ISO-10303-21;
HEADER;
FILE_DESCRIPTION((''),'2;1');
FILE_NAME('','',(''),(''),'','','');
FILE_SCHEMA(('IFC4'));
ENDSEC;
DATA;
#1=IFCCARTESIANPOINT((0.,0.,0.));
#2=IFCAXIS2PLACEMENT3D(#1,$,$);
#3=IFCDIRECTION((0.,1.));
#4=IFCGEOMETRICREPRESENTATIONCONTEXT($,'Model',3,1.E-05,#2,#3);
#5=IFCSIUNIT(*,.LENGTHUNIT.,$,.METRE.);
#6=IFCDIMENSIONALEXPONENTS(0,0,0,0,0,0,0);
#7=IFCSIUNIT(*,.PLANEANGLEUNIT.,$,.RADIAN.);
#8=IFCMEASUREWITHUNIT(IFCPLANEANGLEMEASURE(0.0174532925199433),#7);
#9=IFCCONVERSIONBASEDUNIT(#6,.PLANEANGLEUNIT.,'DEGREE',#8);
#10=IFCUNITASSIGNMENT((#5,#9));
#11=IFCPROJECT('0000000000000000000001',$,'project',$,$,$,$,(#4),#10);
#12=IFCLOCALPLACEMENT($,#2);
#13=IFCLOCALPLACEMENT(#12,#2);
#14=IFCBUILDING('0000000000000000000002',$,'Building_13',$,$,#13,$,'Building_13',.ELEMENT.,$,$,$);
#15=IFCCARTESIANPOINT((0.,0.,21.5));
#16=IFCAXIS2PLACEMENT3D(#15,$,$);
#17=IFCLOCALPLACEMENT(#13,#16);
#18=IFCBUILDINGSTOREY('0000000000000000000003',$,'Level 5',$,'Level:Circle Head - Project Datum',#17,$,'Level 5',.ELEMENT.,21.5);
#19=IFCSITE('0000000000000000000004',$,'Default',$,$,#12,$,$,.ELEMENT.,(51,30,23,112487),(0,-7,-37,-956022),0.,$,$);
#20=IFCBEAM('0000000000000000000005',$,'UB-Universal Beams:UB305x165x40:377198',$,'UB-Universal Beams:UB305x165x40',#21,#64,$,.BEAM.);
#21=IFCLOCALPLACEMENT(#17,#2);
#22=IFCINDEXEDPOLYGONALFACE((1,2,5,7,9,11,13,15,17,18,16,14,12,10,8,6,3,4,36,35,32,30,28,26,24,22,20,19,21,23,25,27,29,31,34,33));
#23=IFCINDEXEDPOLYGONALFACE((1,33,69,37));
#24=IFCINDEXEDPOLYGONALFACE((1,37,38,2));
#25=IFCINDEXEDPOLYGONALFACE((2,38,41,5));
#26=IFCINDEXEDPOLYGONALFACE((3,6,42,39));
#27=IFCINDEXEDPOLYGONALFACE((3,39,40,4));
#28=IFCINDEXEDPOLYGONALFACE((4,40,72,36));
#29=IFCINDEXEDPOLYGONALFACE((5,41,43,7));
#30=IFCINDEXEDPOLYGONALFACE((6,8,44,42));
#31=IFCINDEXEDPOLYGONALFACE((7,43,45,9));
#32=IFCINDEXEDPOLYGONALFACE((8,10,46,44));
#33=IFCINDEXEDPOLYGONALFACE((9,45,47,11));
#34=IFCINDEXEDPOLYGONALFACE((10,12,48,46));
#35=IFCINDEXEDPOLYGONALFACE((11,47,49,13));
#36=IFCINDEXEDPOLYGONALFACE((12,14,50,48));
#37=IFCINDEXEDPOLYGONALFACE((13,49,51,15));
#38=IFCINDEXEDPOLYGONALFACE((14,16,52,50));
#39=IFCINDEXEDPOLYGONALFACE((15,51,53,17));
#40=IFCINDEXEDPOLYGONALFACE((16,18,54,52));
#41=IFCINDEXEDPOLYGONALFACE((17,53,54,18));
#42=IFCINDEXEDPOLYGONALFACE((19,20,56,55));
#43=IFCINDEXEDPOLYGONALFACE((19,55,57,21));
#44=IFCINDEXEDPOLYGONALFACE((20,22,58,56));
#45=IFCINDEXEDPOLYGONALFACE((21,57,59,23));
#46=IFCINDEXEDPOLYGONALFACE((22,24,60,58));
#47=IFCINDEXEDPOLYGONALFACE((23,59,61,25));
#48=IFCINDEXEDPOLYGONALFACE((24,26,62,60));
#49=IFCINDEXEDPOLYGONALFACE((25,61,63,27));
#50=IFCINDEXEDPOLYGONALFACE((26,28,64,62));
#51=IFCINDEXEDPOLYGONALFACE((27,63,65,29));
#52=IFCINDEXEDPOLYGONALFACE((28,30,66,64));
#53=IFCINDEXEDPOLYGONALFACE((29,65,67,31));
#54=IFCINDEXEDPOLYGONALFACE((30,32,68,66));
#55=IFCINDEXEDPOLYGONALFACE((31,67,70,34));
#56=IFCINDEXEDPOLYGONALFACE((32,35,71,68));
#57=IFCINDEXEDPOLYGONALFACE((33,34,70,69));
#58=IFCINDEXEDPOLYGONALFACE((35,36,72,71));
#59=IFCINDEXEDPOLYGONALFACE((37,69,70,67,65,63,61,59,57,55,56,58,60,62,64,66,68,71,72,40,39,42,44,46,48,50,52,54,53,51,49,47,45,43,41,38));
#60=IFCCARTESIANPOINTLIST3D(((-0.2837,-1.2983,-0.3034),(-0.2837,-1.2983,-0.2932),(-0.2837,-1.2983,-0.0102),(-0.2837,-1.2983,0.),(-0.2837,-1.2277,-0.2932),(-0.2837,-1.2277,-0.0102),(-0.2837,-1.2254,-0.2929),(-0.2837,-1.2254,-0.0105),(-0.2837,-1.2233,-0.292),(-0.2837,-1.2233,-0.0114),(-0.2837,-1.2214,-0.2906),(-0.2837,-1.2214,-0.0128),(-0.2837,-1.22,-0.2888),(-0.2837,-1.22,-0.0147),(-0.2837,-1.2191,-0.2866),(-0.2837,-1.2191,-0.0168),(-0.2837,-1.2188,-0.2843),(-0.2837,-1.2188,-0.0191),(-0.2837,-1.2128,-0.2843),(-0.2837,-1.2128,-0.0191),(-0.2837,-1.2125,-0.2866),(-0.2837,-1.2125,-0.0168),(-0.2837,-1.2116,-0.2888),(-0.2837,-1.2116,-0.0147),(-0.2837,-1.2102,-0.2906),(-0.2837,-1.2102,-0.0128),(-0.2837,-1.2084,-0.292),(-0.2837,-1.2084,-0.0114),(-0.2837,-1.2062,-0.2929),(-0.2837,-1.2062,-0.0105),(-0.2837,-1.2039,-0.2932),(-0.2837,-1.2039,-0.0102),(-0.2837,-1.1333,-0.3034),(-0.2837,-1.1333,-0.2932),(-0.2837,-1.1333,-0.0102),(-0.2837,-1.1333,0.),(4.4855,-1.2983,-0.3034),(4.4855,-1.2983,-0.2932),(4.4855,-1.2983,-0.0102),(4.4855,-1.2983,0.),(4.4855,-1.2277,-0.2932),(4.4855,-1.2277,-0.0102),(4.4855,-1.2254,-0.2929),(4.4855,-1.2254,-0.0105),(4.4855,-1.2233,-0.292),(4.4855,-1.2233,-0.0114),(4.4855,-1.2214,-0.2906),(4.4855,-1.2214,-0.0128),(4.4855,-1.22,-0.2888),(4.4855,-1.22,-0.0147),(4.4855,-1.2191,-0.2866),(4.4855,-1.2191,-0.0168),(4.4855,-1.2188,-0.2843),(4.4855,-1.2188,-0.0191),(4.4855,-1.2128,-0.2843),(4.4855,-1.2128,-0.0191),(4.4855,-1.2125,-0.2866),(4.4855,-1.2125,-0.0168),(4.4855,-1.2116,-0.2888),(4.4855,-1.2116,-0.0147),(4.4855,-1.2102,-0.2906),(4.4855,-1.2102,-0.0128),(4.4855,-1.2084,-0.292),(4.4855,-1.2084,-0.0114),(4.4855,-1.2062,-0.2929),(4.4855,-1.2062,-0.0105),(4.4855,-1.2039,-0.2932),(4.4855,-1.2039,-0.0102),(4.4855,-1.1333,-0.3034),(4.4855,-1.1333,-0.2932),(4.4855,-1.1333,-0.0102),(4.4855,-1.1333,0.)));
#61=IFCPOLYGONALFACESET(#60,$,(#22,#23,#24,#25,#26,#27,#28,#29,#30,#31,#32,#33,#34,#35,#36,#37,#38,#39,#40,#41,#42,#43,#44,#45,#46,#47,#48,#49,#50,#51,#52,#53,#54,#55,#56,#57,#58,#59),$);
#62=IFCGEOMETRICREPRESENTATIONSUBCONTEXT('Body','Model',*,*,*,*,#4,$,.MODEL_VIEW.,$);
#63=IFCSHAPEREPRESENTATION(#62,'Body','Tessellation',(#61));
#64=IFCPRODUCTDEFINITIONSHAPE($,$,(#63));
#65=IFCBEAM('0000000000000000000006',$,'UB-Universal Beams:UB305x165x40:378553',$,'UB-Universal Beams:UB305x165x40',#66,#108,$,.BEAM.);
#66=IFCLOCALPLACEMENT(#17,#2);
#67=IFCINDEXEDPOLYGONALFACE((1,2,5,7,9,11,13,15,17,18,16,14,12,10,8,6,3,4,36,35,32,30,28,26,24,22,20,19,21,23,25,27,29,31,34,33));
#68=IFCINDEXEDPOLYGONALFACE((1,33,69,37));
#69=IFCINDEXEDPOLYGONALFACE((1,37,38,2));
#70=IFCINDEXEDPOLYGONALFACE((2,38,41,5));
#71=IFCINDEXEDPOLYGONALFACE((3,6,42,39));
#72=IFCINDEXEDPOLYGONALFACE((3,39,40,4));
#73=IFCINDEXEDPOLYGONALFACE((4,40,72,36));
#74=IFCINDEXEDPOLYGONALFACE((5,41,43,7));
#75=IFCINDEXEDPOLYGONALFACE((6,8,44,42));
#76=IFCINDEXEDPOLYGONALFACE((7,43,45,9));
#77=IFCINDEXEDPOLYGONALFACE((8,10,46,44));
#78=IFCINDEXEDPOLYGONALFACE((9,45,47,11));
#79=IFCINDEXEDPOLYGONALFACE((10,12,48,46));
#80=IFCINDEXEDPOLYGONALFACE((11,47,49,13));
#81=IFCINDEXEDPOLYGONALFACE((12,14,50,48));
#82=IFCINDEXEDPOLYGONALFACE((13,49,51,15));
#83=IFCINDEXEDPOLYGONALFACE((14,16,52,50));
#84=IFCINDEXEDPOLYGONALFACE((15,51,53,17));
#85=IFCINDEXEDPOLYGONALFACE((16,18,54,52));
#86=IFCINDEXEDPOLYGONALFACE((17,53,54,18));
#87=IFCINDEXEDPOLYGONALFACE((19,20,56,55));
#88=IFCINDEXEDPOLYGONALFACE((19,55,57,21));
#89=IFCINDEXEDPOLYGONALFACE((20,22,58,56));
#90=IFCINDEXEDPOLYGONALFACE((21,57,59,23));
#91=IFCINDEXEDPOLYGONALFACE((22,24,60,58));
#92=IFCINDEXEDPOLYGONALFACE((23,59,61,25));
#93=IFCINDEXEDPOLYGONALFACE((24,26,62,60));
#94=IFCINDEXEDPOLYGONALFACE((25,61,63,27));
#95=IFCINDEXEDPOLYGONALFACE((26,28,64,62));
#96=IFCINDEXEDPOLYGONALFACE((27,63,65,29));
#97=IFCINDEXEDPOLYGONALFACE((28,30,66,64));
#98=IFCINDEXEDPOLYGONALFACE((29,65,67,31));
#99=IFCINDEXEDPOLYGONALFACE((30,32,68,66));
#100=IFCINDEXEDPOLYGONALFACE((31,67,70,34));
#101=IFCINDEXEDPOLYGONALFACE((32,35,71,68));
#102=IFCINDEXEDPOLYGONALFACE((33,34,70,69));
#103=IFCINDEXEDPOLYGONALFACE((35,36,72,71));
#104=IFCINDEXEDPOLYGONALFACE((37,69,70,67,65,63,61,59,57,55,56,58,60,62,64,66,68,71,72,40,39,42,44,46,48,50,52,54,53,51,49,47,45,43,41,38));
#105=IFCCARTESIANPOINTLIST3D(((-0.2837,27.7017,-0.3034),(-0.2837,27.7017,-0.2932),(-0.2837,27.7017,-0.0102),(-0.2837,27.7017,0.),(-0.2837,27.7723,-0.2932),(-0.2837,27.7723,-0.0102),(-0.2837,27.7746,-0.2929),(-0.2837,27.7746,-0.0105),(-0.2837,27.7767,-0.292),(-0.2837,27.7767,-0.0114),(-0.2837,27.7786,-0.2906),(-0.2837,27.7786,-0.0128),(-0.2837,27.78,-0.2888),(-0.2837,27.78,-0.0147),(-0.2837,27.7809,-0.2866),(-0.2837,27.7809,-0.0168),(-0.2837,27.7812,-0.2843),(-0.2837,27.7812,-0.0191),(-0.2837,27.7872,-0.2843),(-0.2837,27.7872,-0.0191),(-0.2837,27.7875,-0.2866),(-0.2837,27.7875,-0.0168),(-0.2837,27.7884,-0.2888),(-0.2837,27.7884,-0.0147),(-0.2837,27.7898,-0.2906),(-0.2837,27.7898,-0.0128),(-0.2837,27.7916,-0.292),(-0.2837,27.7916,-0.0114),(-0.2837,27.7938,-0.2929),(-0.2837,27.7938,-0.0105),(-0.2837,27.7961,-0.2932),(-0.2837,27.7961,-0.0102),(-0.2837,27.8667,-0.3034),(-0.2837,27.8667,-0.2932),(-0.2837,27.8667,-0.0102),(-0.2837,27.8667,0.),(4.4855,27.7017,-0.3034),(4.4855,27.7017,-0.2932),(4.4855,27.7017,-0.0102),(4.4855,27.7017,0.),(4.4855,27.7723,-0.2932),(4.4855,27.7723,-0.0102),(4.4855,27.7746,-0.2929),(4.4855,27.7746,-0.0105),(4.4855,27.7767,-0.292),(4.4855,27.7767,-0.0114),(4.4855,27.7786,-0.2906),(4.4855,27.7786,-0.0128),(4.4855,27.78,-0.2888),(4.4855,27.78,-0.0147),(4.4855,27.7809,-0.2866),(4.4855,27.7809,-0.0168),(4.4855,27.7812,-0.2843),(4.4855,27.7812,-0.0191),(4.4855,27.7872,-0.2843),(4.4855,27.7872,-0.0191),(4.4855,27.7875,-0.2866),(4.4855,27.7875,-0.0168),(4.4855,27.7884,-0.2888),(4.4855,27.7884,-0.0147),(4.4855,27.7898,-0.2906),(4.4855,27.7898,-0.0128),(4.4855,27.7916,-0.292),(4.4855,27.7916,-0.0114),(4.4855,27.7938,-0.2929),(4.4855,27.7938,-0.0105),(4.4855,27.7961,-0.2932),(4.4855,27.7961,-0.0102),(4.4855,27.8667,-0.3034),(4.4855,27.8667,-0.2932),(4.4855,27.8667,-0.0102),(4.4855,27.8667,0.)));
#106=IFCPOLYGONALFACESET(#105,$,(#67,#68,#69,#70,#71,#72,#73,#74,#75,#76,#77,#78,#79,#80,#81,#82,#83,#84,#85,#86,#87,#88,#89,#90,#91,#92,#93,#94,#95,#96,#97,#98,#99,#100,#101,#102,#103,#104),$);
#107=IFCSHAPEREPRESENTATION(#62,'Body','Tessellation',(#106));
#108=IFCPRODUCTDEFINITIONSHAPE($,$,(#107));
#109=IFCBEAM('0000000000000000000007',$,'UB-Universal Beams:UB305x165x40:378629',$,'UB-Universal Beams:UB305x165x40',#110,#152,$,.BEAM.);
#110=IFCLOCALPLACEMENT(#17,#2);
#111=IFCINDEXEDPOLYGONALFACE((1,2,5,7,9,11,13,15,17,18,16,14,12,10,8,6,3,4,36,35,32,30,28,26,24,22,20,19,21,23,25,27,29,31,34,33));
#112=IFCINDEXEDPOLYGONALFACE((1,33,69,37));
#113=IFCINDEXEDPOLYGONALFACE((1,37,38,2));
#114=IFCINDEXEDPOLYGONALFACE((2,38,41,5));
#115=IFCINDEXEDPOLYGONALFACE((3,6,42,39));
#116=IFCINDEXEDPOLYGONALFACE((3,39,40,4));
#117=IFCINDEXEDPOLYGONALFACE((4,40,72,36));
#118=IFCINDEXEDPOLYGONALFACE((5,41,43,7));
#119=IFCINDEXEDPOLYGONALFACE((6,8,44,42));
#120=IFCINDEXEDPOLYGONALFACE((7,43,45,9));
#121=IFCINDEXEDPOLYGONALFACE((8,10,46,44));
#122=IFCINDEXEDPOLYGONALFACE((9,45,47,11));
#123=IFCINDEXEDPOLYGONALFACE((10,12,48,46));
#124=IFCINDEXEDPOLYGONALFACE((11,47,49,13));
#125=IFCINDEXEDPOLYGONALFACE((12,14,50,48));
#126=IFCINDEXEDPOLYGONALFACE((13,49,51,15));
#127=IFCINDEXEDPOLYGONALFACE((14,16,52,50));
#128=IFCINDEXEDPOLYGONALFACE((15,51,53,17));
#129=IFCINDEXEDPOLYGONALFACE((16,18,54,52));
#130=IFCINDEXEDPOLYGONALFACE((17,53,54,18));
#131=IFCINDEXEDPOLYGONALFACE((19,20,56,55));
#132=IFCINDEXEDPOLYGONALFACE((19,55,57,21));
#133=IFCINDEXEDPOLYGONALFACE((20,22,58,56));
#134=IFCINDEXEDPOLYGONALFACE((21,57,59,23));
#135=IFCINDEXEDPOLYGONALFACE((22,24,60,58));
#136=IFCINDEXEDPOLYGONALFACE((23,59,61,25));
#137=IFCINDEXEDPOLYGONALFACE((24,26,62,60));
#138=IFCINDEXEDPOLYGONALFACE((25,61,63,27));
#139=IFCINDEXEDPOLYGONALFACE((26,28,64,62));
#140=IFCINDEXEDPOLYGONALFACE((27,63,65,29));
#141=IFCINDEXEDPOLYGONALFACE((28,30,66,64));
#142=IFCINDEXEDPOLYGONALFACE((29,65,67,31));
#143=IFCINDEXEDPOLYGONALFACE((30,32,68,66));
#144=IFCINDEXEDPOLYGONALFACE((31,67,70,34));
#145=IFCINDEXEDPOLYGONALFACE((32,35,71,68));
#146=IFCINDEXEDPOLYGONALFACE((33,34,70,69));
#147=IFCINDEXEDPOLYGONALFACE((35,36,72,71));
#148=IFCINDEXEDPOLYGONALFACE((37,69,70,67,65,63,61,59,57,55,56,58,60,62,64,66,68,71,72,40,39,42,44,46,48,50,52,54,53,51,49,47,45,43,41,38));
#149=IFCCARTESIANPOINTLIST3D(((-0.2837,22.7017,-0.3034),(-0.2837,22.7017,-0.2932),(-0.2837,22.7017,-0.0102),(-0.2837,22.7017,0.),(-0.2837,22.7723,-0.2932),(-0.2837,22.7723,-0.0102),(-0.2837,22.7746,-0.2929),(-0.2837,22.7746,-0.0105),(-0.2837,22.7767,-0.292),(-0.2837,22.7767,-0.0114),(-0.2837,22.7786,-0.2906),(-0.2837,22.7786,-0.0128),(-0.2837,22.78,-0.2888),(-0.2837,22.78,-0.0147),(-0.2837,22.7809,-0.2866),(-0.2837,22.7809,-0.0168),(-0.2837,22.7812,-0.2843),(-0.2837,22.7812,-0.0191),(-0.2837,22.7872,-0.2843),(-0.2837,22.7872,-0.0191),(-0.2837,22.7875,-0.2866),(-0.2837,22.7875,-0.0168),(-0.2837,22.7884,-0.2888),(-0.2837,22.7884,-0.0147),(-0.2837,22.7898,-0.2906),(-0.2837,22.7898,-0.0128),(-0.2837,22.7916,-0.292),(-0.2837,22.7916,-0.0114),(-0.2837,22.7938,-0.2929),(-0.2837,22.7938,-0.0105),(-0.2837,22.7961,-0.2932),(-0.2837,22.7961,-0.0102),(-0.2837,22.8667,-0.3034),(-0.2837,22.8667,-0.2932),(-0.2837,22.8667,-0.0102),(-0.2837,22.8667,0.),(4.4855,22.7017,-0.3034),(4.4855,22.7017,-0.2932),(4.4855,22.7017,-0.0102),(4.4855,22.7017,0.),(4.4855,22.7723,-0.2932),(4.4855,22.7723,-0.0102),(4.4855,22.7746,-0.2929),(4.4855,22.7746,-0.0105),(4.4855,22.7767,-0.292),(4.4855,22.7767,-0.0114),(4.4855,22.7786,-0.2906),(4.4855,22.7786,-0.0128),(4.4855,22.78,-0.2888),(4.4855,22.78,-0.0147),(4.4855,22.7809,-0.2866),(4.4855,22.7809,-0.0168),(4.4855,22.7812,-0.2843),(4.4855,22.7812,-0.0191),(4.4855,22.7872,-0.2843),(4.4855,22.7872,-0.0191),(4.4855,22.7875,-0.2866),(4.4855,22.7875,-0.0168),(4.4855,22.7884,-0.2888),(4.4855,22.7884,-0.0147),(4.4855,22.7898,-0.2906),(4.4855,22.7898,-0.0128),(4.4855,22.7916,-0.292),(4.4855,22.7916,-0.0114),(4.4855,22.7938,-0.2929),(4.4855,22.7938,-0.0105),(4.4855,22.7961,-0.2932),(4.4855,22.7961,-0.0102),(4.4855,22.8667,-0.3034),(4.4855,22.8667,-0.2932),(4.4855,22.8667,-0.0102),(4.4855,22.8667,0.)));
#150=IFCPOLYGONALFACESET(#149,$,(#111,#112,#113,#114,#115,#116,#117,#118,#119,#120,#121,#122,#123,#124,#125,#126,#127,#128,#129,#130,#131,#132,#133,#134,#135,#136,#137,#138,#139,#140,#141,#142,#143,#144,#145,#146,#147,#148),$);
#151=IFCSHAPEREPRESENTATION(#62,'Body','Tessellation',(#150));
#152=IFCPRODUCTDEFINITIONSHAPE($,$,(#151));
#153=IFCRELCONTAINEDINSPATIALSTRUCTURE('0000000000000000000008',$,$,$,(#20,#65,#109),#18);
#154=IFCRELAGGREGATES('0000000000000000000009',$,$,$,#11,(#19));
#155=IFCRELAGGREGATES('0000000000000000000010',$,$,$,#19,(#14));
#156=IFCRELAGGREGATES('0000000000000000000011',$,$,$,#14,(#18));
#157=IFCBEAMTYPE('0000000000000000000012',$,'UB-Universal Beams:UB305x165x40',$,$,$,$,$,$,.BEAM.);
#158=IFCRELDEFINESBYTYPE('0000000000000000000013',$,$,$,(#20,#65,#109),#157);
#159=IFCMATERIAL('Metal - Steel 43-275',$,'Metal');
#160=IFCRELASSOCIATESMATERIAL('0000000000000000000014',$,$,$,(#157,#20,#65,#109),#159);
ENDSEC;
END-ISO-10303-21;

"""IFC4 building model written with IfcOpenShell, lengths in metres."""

from ifc_helpers import new_model, entity, si_unit, converted_unit, direction, frame, origin, place, context, subcontext, project, spatial, line, arc, indexed_curve, outline, extrude, source, transform, mapped, material, type_object, type_shapes, element, save


model = new_model("IFC4")

# Units and contexts
model_context = context("Model", 3, precision=1e-05, world=origin(), true_north=direction((0.0, 1.0)))
body_context = subcontext(model_context, "Body", "Model", "MODEL_VIEW")
ifc_project = project(units=[si_unit("LENGTHUNIT", "METRE"), converted_unit("PLANEANGLEUNIT", "DEGREE", entity("IfcPlaneAngleMeasure", 0.0174532925199433), si_unit("PLANEANGLEUNIT", "RADIAN"), dimensions=[0, 0, 0, 0, 0, 0, 0])], contexts=[model_context])

# Site, building, storey
site_placement = place(None, origin())
site = spatial("IfcSite", under=ifc_project, at=site_placement, Name="Default", CompositionType="ELEMENT", RefLatitude=(51, 30, 23, 112487), RefLongitude=(0, -7, -37, -956022), RefElevation=0.0)
building_placement = place(site_placement, origin())
building = spatial("IfcBuilding", under=site, at=building_placement, Name="Building_13", LongName="Building_13", CompositionType="ELEMENT")
storey_placement = place(building_placement, frame((0.0, 0.0, 21.5)))
storey = spatial("IfcBuildingStorey", under=building, at=storey_placement, Name="Level 5", ObjectType="Level:Circle Head - Project Datum", LongName="Level 5", CompositionType="ELEMENT", Elevation=21.5)

# Beams
ifc_material = material(Name="Metal - Steel 43-275", Category="Metal")
beam_type_1 = type_object("IfcBeamType", Name="UB-Universal Beams:UB305x165x40", PredefinedType="BEAM", material=ifc_material)
shared_shape_1 = source(origin(), body_context, "Body", "SweptSolid", [
    extrude(outline(indexed_curve([(-0.0825, -0.1415), (-0.0825, -0.1517), (0.0825, -0.1517), (0.0825, -0.1415), (0.0119, -0.1415), (0.0056, -0.1389), (0.003, -0.1326), (0.003, 0.1326), (0.0056, 0.1389), (0.0119, 0.1415), (0.0825, 0.1415), (0.0825, 0.1517), (-0.0825, 0.1517), (-0.0825, 0.1415), (-0.0119, 0.1415), (-0.0056, 0.1389), (-0.003, 0.1326), (-0.003, -0.1326), (-0.0056, -0.1389), (-0.0119, -0.1415)], segments=[line(1, 2, 3, 4, 5), arc(5, 6, 7), line(7, 8), arc(8, 9, 10), line(10, 11, 12, 13, 14, 15), arc(15, 16, 17), line(17, 18), arc(18, 19, 20), line(20, 1)], self_intersect=False)), frame((-2.3846, 0.0, 0.0), z_axis=(-1.0, 0.0, 0.0), x_axis=(0.0, -1.0, 0.0)), (0.0, 0.0, -1.0), 4.7692),
])
type_shapes(beam_type_1, [shared_shape_1])
beam_1_placement = place(storey_placement, frame((2.1009, -1.2158, -0.1517), z_axis=(0.0, 0.0, 1.0), x_axis=(-1.0, 0.0, 0.0)))
element("IfcBeam", 1, at=beam_1_placement, inside=storey, type_object=beam_type_1, material=ifc_material, Name="UB-Universal Beams:UB305x165x40:377198", ObjectType="UB-Universal Beams:UB305x165x40", PredefinedType="BEAM", context=body_context, shape_type="MappedRepresentation", body=[
    mapped(shared_shape_1, transform((0.0, 0.0, 0.0), scale=1.0)),
])
beam_2_placement = place(storey_placement, frame((2.1009, 27.7842, -0.1517)))
element("IfcBeam", 2, at=beam_2_placement, inside=storey, type_object=beam_type_1, material=ifc_material, Name="UB-Universal Beams:UB305x165x40:378553", ObjectType="UB-Universal Beams:UB305x165x40", PredefinedType="BEAM", context=body_context, shape_type="MappedRepresentation", body=[
    mapped(shared_shape_1, transform((0.0, 0.0, 0.0), scale=1.0)),
])
beam_3_placement = place(storey_placement, frame((2.1009, 22.7842, -0.1517), z_axis=(0.0, 0.0, 1.0), x_axis=(-1.0, 0.0, 0.0)))
element("IfcBeam", 3, at=beam_3_placement, inside=storey, type_object=beam_type_1, material=ifc_material, Name="UB-Universal Beams:UB305x165x40:378629", ObjectType="UB-Universal Beams:UB305x165x40", PredefinedType="BEAM", context=body_context, shape_type="MappedRepresentation", body=[
    mapped(shared_shape_1, transform((0.0, 0.0, 0.0), scale=1.0)),
])

save(model, "model.ifc")
